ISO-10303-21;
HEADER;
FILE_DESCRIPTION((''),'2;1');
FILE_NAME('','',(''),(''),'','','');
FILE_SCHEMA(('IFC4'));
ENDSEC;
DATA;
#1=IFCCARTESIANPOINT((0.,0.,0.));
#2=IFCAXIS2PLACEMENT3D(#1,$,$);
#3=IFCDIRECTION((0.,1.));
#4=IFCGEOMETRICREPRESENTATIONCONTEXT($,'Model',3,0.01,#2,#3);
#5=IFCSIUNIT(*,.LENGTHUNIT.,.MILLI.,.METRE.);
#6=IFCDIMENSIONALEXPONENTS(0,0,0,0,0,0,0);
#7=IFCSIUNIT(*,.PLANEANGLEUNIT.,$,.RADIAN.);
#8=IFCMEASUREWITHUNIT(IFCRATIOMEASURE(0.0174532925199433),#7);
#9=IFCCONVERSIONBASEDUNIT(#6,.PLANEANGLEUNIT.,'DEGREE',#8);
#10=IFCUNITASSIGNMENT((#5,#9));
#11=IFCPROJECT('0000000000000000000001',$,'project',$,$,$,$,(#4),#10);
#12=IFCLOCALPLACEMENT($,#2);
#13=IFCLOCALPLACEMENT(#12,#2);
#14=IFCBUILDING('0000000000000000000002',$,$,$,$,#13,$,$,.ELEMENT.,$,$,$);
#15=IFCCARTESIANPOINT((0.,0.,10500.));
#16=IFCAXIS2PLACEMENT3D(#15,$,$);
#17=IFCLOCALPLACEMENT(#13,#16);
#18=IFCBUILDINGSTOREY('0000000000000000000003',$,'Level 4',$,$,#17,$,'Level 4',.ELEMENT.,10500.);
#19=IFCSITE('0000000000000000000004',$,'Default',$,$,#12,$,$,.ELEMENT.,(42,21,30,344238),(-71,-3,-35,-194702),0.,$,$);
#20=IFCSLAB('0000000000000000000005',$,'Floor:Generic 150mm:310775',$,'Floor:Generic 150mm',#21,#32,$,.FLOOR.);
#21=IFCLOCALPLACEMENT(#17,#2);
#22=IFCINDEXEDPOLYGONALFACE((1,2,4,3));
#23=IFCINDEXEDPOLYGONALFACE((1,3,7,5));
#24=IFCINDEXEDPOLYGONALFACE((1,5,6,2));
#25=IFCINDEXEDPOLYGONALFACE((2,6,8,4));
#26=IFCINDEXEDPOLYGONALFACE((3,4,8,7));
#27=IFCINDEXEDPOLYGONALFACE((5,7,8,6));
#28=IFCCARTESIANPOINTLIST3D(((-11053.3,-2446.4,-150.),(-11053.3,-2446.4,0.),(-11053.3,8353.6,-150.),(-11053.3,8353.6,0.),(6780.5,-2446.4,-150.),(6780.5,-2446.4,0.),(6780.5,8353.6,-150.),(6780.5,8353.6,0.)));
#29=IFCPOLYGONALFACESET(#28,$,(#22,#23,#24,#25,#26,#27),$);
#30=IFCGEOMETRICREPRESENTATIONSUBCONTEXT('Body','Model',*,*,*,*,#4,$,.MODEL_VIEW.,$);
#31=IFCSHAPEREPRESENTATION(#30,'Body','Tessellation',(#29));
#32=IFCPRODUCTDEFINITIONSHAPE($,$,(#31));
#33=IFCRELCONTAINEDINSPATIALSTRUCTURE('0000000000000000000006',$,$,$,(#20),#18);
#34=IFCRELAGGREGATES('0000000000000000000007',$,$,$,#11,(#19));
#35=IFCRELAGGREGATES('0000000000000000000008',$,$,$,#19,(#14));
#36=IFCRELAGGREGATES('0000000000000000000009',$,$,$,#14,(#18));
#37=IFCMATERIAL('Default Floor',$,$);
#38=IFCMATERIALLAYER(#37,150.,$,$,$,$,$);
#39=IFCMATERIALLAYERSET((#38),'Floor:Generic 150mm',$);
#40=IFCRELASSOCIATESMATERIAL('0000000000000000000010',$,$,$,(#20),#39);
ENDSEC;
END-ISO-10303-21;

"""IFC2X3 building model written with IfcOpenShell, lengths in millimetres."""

from ifc_helpers import new_model, entity, si_unit, converted_unit, direction, frame, origin, origin_2d_with_axis, place, context, subcontext, project, spatial, rectangle, extrude, material, layer, layer_set, layer_usage, element, save


model = new_model("IFC2X3")

# Units and contexts
model_context = context("Model", 3, precision=0.01, world=origin(), true_north=direction((0.0, 1.0)))
body_context = subcontext(model_context, "Body", "Model", "MODEL_VIEW")
ifc_project = project(units=[si_unit("LENGTHUNIT", "METRE", prefix="MILLI"), converted_unit("PLANEANGLEUNIT", "DEGREE", entity("IfcRatioMeasure", 0.0174532925199433), si_unit("PLANEANGLEUNIT", "RADIAN"), dimensions=[0, 0, 0, 0, 0, 0, 0])], contexts=[model_context])

# Site, building, storey
site_placement = place(None, origin())
site = spatial("IfcSite", under=ifc_project, at=site_placement, Name="Default", CompositionType="ELEMENT", RefLatitude=(42, 21, 30, 344238), RefLongitude=(-71, -3, -35, -194702), RefElevation=0.0)
building_placement = place(site_placement, origin())
building = spatial("IfcBuilding", under=site, at=building_placement, CompositionType="ELEMENT")
storey_placement = place(building_placement, frame((0.0, 0.0, 10500.0)))
storey = spatial("IfcBuildingStorey", under=building, at=storey_placement, Name="Level 4", LongName="Level 4", CompositionType="ELEMENT", Elevation=10500.0)

# Slab
ifc_material = material(Name="Default Floor")
ifc_layer = layer(ifc_material, 150.0)
ifc_layer_set = layer_set([ifc_layer], Name="Floor:Generic 150mm")
ifc_layer_usage = layer_usage(ifc_layer_set, "AXIS3", "POSITIVE", 0.0)
slab_placement = place(storey_placement, origin())
element("IfcSlab", 1, at=slab_placement, inside=storey, material=ifc_layer_usage, Name="Floor:Generic 150mm:310775", ObjectType="Floor:Generic 150mm", PredefinedType="FLOOR", context=body_context, shape_type="SweptSolid", body=[
    extrude(rectangle(XDim=10800.0, YDim=17833.8, at=origin_2d_with_axis()), frame((-2136.4, 2953.6, 0.0), z_axis=(0.0, 0.0, -1.0), x_axis=(0.0, 1.0, 0.0)), (0.0, 0.0, 1.0), 150.0),
])

save(model, "model.ifc")
